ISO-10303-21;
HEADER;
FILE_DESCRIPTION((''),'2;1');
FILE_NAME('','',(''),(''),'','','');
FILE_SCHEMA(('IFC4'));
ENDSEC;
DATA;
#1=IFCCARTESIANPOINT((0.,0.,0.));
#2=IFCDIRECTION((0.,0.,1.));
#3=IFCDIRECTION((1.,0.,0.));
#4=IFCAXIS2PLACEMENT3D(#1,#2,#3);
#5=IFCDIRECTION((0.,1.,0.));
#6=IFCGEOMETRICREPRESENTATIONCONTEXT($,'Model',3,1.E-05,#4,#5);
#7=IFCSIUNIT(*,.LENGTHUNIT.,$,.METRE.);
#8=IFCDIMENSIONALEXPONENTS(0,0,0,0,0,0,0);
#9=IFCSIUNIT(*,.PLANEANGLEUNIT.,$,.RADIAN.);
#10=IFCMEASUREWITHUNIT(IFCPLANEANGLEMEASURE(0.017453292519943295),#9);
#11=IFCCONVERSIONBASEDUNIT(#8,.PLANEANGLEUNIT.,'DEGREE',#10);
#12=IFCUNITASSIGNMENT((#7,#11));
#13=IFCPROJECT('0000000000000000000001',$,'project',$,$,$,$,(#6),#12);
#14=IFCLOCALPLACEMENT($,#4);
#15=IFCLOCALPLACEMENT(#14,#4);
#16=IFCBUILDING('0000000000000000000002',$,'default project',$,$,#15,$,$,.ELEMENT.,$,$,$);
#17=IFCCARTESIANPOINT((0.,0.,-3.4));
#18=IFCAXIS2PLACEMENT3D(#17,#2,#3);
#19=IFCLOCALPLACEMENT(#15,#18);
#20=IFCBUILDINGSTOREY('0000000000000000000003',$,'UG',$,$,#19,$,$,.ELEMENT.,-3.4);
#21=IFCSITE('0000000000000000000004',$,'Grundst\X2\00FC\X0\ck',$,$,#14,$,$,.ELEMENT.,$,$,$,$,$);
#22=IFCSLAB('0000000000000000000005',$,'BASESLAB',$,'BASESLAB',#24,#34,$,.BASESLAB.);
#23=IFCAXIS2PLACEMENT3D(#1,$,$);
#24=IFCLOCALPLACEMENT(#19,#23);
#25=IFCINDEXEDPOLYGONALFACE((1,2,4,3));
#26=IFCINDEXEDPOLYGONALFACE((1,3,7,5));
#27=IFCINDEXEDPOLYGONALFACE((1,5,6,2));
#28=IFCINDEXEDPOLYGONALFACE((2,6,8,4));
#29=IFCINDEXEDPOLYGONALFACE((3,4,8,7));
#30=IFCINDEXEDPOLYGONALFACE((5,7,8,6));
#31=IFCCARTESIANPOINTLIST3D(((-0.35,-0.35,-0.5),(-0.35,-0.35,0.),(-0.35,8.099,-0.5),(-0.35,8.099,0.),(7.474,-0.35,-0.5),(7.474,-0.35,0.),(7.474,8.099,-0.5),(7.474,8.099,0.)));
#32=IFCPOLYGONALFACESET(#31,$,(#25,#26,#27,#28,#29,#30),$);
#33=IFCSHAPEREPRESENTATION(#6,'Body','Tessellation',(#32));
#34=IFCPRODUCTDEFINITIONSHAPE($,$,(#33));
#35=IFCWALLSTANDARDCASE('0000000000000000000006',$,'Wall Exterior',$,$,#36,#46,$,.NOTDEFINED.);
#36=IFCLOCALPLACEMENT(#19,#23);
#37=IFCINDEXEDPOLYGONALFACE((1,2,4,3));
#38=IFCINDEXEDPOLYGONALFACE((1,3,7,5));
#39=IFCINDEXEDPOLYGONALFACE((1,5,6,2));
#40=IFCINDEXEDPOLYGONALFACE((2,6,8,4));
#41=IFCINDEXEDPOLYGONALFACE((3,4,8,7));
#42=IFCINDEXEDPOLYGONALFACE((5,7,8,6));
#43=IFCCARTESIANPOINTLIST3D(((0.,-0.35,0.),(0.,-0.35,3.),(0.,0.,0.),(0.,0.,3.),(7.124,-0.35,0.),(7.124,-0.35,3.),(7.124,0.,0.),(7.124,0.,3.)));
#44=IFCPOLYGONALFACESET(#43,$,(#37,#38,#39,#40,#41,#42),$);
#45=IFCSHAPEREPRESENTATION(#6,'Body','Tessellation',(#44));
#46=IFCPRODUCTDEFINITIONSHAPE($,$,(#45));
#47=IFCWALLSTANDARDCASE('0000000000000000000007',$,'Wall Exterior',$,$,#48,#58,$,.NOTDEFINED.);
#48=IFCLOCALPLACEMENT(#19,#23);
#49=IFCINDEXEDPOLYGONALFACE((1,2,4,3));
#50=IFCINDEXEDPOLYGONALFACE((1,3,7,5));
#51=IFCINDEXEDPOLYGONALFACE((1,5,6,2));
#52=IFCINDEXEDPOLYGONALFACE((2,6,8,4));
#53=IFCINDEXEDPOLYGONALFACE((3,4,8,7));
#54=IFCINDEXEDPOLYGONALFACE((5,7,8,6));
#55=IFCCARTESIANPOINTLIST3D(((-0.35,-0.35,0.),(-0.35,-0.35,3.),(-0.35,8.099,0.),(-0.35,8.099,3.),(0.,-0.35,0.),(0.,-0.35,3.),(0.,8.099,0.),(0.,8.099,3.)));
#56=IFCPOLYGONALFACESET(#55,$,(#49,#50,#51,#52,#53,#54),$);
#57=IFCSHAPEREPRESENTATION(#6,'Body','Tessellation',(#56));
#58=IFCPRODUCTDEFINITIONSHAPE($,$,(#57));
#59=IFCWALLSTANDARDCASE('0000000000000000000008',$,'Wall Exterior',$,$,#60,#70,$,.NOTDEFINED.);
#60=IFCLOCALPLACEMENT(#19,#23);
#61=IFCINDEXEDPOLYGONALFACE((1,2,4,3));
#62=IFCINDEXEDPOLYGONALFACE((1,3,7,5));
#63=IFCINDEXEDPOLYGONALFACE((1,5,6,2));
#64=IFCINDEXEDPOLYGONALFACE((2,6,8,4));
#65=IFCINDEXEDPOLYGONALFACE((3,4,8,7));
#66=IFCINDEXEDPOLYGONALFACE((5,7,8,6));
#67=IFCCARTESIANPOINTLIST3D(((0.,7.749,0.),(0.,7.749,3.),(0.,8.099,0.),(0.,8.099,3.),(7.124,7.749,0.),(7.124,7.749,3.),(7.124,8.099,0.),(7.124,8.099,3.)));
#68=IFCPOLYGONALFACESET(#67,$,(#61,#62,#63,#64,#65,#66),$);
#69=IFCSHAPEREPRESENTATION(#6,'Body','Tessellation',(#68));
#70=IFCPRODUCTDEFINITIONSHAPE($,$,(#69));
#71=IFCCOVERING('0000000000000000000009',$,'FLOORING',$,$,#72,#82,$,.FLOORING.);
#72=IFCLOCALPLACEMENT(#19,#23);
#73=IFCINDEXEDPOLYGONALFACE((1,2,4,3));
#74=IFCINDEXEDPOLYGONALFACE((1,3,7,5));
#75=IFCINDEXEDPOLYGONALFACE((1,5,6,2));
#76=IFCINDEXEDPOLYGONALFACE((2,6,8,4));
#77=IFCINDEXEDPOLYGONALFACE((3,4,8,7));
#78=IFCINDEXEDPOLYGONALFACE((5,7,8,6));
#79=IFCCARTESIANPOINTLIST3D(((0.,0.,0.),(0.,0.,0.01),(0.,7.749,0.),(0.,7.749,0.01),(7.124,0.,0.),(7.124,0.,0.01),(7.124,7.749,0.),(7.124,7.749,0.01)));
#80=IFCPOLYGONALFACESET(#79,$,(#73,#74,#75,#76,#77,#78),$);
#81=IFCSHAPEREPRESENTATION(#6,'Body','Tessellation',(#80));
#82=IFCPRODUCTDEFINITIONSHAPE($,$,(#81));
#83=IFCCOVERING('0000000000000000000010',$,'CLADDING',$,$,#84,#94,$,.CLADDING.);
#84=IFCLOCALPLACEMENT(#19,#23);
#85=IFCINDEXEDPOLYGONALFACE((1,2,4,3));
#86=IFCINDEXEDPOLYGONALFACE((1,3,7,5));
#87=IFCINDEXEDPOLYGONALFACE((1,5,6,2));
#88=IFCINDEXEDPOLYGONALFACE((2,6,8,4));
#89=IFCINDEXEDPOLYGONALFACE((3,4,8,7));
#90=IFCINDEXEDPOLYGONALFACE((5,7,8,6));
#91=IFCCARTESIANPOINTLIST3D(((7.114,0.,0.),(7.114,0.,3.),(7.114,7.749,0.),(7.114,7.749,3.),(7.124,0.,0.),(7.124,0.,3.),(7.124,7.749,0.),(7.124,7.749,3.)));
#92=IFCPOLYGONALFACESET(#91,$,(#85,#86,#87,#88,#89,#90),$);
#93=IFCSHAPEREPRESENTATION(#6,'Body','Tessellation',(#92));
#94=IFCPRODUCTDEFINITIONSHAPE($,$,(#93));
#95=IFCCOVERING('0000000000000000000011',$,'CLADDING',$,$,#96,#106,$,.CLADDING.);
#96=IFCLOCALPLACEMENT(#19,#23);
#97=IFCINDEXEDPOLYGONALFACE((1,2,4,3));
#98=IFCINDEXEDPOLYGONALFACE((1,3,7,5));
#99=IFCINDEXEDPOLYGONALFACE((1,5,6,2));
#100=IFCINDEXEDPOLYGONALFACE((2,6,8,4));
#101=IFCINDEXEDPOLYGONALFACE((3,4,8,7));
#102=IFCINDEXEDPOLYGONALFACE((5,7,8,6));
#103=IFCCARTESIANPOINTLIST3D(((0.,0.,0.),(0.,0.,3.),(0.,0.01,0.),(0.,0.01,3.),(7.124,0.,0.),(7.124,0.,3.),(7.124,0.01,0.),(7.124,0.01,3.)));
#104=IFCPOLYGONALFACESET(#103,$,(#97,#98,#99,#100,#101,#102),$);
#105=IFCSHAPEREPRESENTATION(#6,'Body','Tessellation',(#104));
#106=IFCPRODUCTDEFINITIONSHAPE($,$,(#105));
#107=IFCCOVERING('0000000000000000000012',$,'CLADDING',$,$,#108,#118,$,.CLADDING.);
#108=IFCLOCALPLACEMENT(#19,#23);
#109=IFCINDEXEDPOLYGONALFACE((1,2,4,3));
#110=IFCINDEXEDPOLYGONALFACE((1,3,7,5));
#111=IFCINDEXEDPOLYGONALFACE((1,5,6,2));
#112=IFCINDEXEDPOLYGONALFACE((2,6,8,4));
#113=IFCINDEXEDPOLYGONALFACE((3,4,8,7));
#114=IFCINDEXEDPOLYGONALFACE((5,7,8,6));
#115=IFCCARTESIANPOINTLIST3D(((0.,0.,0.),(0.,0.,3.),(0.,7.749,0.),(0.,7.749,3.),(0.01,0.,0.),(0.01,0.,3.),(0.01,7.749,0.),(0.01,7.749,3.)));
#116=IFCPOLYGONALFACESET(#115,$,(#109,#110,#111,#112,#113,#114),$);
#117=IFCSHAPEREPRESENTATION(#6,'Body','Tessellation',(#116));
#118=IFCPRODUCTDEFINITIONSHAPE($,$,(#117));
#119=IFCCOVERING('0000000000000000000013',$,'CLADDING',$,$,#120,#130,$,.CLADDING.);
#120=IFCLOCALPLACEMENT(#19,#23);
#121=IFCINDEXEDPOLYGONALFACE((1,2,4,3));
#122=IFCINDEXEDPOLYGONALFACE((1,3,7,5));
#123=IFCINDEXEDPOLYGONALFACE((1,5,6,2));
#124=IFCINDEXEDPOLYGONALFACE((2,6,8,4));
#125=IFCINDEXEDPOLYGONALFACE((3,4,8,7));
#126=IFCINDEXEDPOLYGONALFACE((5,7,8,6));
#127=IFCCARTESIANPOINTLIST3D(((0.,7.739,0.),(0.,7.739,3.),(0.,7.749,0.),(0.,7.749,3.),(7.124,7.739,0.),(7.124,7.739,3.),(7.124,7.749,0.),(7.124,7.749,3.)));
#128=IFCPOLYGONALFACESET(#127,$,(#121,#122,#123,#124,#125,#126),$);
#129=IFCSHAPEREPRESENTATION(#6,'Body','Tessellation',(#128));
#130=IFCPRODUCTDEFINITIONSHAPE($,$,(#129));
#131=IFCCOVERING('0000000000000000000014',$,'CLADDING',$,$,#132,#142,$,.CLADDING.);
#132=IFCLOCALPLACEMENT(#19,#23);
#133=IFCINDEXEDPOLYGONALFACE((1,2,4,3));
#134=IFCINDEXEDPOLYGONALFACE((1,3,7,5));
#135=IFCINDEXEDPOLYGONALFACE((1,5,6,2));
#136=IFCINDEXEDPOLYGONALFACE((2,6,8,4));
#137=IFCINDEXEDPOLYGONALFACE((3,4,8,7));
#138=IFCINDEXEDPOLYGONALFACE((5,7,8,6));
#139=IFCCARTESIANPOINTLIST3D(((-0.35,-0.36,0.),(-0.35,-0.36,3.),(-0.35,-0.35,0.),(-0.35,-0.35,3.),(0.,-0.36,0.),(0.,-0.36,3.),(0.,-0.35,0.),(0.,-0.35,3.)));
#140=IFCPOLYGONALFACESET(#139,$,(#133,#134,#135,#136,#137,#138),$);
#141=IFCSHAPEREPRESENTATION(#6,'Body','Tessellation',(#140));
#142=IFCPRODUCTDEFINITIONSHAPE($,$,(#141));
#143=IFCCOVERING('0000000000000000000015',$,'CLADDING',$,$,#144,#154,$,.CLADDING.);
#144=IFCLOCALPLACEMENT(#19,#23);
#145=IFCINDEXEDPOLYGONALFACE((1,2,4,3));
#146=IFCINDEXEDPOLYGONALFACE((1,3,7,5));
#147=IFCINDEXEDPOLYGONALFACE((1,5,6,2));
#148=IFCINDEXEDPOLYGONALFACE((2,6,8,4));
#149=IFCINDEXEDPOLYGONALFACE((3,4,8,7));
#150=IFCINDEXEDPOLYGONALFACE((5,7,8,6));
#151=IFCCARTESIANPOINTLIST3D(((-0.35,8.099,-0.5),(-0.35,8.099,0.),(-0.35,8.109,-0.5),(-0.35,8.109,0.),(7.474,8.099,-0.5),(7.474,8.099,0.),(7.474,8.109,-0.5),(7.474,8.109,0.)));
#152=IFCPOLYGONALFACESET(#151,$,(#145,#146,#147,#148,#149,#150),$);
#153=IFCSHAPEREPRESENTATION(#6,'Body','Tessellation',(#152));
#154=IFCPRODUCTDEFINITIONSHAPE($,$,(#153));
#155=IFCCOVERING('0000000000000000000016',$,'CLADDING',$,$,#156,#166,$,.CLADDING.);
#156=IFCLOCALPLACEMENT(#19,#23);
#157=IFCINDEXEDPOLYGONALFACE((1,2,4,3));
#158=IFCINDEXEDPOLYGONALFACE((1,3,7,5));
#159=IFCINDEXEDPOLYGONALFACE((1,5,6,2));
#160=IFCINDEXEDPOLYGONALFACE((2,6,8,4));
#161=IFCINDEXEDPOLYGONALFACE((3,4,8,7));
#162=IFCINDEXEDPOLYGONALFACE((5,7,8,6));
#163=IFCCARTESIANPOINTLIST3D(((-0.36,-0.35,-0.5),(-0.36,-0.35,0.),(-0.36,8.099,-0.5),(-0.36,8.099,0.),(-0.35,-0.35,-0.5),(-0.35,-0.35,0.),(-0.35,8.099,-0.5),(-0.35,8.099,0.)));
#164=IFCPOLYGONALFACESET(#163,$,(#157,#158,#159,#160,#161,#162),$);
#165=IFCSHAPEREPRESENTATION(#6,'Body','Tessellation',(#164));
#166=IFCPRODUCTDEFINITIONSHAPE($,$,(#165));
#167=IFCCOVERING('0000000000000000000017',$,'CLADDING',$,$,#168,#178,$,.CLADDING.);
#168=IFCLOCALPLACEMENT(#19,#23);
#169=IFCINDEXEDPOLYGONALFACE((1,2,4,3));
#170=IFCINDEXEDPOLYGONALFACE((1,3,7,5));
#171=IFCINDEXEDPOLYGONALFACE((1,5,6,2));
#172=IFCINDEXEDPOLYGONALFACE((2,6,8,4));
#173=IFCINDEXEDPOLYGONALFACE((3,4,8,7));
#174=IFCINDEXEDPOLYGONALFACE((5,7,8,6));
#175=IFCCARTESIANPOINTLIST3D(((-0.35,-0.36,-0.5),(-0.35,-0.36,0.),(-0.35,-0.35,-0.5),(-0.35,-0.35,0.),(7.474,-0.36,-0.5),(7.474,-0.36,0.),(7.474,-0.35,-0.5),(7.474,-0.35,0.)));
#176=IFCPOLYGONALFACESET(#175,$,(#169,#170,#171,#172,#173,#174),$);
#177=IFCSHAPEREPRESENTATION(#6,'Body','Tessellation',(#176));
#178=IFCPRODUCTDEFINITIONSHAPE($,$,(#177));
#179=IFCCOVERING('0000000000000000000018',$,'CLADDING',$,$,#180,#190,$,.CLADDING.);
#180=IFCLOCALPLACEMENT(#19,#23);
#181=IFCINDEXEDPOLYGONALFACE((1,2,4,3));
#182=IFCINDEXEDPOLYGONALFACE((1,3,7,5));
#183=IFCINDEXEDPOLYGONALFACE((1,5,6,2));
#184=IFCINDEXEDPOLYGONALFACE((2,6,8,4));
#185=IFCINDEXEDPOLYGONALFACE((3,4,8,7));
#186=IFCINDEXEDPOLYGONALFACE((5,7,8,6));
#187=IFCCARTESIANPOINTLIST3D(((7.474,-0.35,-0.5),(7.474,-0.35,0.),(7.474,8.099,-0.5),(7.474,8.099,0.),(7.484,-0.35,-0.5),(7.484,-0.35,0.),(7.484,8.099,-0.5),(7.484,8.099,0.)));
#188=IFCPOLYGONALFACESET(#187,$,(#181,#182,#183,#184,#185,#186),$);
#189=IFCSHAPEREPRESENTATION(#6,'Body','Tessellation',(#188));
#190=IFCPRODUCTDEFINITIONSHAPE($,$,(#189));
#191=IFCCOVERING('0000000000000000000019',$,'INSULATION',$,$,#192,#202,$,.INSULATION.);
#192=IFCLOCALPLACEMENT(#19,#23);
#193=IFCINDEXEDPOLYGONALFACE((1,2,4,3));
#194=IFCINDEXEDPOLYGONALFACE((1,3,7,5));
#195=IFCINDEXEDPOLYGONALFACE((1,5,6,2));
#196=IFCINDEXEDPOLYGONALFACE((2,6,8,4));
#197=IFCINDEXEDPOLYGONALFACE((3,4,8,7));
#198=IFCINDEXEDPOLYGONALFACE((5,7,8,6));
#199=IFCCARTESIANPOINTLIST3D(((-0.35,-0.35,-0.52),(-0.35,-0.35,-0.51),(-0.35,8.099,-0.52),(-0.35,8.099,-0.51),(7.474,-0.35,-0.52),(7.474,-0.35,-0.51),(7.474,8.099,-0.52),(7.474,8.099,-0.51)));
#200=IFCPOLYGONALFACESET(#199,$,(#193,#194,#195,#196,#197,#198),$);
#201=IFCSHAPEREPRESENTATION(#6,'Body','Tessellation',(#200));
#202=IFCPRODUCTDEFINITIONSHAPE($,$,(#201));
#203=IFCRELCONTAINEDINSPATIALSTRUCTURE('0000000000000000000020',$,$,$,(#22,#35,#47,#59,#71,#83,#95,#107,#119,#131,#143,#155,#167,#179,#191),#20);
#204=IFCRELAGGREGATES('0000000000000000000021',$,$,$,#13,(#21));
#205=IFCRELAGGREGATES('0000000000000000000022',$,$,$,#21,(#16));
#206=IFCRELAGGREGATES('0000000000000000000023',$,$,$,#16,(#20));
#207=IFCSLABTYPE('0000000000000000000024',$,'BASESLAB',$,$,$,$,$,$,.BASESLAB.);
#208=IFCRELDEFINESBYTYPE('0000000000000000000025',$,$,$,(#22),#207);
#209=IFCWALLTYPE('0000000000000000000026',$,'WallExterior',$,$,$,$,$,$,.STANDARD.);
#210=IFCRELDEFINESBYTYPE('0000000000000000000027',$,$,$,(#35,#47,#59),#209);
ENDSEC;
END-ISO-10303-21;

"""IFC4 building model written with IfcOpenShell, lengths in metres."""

from ifc_helpers import new_model, entity, si_unit, converted_unit, direction, frame, origin_with_axes, place, context, project, spatial, polyline, outline, extrude, type_object, element, save


model = new_model("IFC4")

# Units and contexts
model_context = context("Model", 3, precision=1e-05, world=origin_with_axes(), true_north=direction((0.0, 1.0, 0.0)))
ifc_project = project(units=[si_unit("LENGTHUNIT", "METRE"), converted_unit("PLANEANGLEUNIT", "DEGREE", entity("IfcPlaneAngleMeasure", 0.017453292519943295), si_unit("PLANEANGLEUNIT", "RADIAN"), dimensions=[0, 0, 0, 0, 0, 0, 0])], contexts=[model_context])

# Site, building, storey
site_placement = place(None, origin_with_axes())
site = spatial("IfcSite", under=ifc_project, at=site_placement, Name="Grundstück", CompositionType="ELEMENT")
building_placement = place(site_placement, origin_with_axes())
building = spatial("IfcBuilding", under=site, at=building_placement, Name="default project", CompositionType="ELEMENT")
placement_1 = place(building_placement, frame((0.0, 0.0, -3.4), z_axis=(0.0, 0.0, 1.0), x_axis=(1.0, 0.0, 0.0)))
storey = spatial("IfcBuildingStorey", under=building, at=placement_1, Name="UG", CompositionType="ELEMENT", Elevation=-3.4)

# Slab
slab_type = type_object("IfcSlabType", Name="BASESLAB", PredefinedType="BASESLAB")
slab_placement = place(placement_1, frame((0.0, 0.0, -0.5), z_axis=(0.0, 0.0, 1.0), x_axis=(1.0, 0.0, 0.0)))
element("IfcSlab", 1, at=slab_placement, inside=storey, type_object=slab_type, Name="BASESLAB", ObjectType="BASESLAB", PredefinedType="BASESLAB", context=model_context, shape_type="SweptSolid", body=[
    extrude(outline(polyline([(7.474, 8.099), (-0.35, 8.099), (-0.35, -0.35), (7.474, -0.35), (7.474, 8.099)])), origin_with_axes(), (0.0, 0.0, 1.0), 0.5),
])

# Walls
wall_type = type_object("IfcWallType", Name="WallExterior", PredefinedType="STANDARD")
placement_2 = place(placement_1, frame((7.299, -0.175, 0.0), z_axis=(0.0, 0.0, 1.0), x_axis=(-1.0, 0.0, 0.0)))
element("IfcWallStandardCase", 2, at=placement_2, inside=storey, type_object=wall_type, Name="Wall Exterior", PredefinedType="NOTDEFINED", context=model_context, shape_type="SweptSolid", body=[
    extrude(outline(polyline([(0.175, -0.175), (7.299, -0.175), (7.299, 0.175), (0.175, 0.175), (0.175, -0.175)])), origin_with_axes(), (0.0, 0.0, 1.0), 3.0),
])
placement_3 = place(placement_1, frame((-0.175, -0.175, 0.0), z_axis=(0.0, 0.0, 1.0), x_axis=(0.0, 1.0, 0.0)))
element("IfcWallStandardCase", 3, at=placement_3, inside=storey, type_object=wall_type, Name="Wall Exterior", PredefinedType="NOTDEFINED", context=model_context, shape_type="SweptSolid", body=[
    extrude(outline(polyline([(-0.175, -0.175), (8.274, -0.175), (8.274, 0.175), (-0.175, 0.175), (-0.175, -0.175)])), origin_with_axes(), (0.0, 0.0, 1.0), 3.0),
])
placement_4 = place(placement_1, frame((-0.175, 7.924, 0.0), z_axis=(0.0, 0.0, 1.0), x_axis=(1.0, 0.0, 0.0)))
element("IfcWallStandardCase", 4, at=placement_4, inside=storey, type_object=wall_type, Name="Wall Exterior", PredefinedType="NOTDEFINED", context=model_context, shape_type="SweptSolid", body=[
    extrude(outline(polyline([(7.299, 0.175), (0.175, 0.175), (0.175, -0.175), (7.299, -0.175), (7.299, 0.175)])), origin_with_axes(), (0.0, 0.0, 1.0), 3.0),
])

# Coverings
element("IfcCovering", 5, at=placement_1, inside=storey, Name="FLOORING", PredefinedType="FLOORING", context=model_context, shape_type="SweptSolid", body=[
    extrude(outline(polyline([(7.124, 7.749), (0.0, 7.749), (0.0, 0.0), (7.124, 0.0), (7.124, 7.749)])), origin_with_axes(), (0.0, 0.0, 1.0), 0.01),
])
element("IfcCovering", 6, at=placement_1, inside=storey, Name="CLADDING", PredefinedType="CLADDING", context=model_context, shape_type="SweptSolid", body=[
    extrude(outline(polyline([(7.114, 7.749), (7.114, 0.0), (7.124, 0.0), (7.124, 7.749), (7.114, 7.749)])), origin_with_axes(), (0.0, 0.0, 1.0), 3.0),
])
element("IfcCovering", 7, at=placement_1, inside=storey, Name="CLADDING", PredefinedType="CLADDING", context=model_context, shape_type="SweptSolid", body=[
    extrude(outline(polyline([(7.124, 0.01), (0.0, 0.01), (0.0, 0.0), (7.124, 0.0), (7.124, 0.01)])), origin_with_axes(), (0.0, 0.0, 1.0), 3.0),
])
element("IfcCovering", 8, at=placement_1, inside=storey, Name="CLADDING", PredefinedType="CLADDING", context=model_context, shape_type="SweptSolid", body=[
    extrude(outline(polyline([(0.01, 0.0), (0.01, 7.749), (0.0, 7.749), (0.0, 0.0), (0.01, 0.0)])), origin_with_axes(), (0.0, 0.0, 1.0), 3.0),
])
element("IfcCovering", 9, at=placement_1, inside=storey, Name="CLADDING", PredefinedType="CLADDING", context=model_context, shape_type="SweptSolid", body=[
    extrude(outline(polyline([(0.0, 7.739), (7.124, 7.739), (7.124, 7.749), (0.0, 7.749), (0.0, 7.739)])), origin_with_axes(), (0.0, 0.0, 1.0), 3.0),
])
element("IfcCovering", 10, at=placement_3, inside=storey, Name="CLADDING", PredefinedType="CLADDING", context=model_context, shape_type="SweptSolid", body=[
    extrude(outline(polyline([(-0.185, 0.175), (-0.185, -0.175), (-0.175, -0.175), (-0.175, 0.175), (-0.185, 0.175)])), origin_with_axes(), (0.0, 0.0, 1.0), 3.0),
])
covering_1_placement = place(slab_placement, origin_with_axes())
element("IfcCovering", 11, at=covering_1_placement, inside=storey, Name="CLADDING", PredefinedType="CLADDING", context=model_context, shape_type="SweptSolid", body=[
    extrude(outline(polyline([(7.474, 8.109), (-0.35, 8.109), (-0.35, 8.099), (7.474, 8.099), (7.474, 8.109)])), origin_with_axes(), (0.0, 0.0, 1.0), 0.5),
])
covering_2_placement = place(slab_placement, origin_with_axes())
element("IfcCovering", 12, at=covering_2_placement, inside=storey, Name="CLADDING", PredefinedType="CLADDING", context=model_context, shape_type="SweptSolid", body=[
    extrude(outline(polyline([(-0.36, 8.099), (-0.36, -0.35), (-0.35, -0.35), (-0.35, 8.099), (-0.36, 8.099)])), origin_with_axes(), (0.0, 0.0, 1.0), 0.5),
])
covering_3_placement = place(slab_placement, origin_with_axes())
element("IfcCovering", 13, at=covering_3_placement, inside=storey, Name="CLADDING", PredefinedType="CLADDING", context=model_context, shape_type="SweptSolid", body=[
    extrude(outline(polyline([(-0.35, -0.36), (7.474, -0.36), (7.474, -0.35), (-0.35, -0.35), (-0.35, -0.36)])), origin_with_axes(), (0.0, 0.0, 1.0), 0.5),
])
covering_4_placement = place(slab_placement, origin_with_axes())
element("IfcCovering", 14, at=covering_4_placement, inside=storey, Name="CLADDING", PredefinedType="CLADDING", context=model_context, shape_type="SweptSolid", body=[
    extrude(outline(polyline([(7.484, -0.35), (7.484, 8.099), (7.474, 8.099), (7.474, -0.35), (7.484, -0.35)])), origin_with_axes(), (0.0, 0.0, 1.0), 0.5),
])
covering_5_placement = place(slab_placement, frame((0.0, 0.0, -0.01), z_axis=(0.0, 0.0, 1.0), x_axis=(1.0, 0.0, 0.0)))
element("IfcCovering", 15, at=covering_5_placement, inside=storey, Name="INSULATION", PredefinedType="INSULATION", context=model_context, shape_type="SweptSolid", body=[
    extrude(outline(polyline([(7.474, 8.099), (-0.35, 8.099), (-0.35, -0.35), (7.474, -0.35), (7.474, 8.099)])), frame((0.0, 0.0, -0.01), z_axis=(0.0, 0.0, 1.0), x_axis=(1.0, 0.0, 0.0)), (0.0, 0.0, 1.0), 0.01),
])

save(model, "model.ifc")
